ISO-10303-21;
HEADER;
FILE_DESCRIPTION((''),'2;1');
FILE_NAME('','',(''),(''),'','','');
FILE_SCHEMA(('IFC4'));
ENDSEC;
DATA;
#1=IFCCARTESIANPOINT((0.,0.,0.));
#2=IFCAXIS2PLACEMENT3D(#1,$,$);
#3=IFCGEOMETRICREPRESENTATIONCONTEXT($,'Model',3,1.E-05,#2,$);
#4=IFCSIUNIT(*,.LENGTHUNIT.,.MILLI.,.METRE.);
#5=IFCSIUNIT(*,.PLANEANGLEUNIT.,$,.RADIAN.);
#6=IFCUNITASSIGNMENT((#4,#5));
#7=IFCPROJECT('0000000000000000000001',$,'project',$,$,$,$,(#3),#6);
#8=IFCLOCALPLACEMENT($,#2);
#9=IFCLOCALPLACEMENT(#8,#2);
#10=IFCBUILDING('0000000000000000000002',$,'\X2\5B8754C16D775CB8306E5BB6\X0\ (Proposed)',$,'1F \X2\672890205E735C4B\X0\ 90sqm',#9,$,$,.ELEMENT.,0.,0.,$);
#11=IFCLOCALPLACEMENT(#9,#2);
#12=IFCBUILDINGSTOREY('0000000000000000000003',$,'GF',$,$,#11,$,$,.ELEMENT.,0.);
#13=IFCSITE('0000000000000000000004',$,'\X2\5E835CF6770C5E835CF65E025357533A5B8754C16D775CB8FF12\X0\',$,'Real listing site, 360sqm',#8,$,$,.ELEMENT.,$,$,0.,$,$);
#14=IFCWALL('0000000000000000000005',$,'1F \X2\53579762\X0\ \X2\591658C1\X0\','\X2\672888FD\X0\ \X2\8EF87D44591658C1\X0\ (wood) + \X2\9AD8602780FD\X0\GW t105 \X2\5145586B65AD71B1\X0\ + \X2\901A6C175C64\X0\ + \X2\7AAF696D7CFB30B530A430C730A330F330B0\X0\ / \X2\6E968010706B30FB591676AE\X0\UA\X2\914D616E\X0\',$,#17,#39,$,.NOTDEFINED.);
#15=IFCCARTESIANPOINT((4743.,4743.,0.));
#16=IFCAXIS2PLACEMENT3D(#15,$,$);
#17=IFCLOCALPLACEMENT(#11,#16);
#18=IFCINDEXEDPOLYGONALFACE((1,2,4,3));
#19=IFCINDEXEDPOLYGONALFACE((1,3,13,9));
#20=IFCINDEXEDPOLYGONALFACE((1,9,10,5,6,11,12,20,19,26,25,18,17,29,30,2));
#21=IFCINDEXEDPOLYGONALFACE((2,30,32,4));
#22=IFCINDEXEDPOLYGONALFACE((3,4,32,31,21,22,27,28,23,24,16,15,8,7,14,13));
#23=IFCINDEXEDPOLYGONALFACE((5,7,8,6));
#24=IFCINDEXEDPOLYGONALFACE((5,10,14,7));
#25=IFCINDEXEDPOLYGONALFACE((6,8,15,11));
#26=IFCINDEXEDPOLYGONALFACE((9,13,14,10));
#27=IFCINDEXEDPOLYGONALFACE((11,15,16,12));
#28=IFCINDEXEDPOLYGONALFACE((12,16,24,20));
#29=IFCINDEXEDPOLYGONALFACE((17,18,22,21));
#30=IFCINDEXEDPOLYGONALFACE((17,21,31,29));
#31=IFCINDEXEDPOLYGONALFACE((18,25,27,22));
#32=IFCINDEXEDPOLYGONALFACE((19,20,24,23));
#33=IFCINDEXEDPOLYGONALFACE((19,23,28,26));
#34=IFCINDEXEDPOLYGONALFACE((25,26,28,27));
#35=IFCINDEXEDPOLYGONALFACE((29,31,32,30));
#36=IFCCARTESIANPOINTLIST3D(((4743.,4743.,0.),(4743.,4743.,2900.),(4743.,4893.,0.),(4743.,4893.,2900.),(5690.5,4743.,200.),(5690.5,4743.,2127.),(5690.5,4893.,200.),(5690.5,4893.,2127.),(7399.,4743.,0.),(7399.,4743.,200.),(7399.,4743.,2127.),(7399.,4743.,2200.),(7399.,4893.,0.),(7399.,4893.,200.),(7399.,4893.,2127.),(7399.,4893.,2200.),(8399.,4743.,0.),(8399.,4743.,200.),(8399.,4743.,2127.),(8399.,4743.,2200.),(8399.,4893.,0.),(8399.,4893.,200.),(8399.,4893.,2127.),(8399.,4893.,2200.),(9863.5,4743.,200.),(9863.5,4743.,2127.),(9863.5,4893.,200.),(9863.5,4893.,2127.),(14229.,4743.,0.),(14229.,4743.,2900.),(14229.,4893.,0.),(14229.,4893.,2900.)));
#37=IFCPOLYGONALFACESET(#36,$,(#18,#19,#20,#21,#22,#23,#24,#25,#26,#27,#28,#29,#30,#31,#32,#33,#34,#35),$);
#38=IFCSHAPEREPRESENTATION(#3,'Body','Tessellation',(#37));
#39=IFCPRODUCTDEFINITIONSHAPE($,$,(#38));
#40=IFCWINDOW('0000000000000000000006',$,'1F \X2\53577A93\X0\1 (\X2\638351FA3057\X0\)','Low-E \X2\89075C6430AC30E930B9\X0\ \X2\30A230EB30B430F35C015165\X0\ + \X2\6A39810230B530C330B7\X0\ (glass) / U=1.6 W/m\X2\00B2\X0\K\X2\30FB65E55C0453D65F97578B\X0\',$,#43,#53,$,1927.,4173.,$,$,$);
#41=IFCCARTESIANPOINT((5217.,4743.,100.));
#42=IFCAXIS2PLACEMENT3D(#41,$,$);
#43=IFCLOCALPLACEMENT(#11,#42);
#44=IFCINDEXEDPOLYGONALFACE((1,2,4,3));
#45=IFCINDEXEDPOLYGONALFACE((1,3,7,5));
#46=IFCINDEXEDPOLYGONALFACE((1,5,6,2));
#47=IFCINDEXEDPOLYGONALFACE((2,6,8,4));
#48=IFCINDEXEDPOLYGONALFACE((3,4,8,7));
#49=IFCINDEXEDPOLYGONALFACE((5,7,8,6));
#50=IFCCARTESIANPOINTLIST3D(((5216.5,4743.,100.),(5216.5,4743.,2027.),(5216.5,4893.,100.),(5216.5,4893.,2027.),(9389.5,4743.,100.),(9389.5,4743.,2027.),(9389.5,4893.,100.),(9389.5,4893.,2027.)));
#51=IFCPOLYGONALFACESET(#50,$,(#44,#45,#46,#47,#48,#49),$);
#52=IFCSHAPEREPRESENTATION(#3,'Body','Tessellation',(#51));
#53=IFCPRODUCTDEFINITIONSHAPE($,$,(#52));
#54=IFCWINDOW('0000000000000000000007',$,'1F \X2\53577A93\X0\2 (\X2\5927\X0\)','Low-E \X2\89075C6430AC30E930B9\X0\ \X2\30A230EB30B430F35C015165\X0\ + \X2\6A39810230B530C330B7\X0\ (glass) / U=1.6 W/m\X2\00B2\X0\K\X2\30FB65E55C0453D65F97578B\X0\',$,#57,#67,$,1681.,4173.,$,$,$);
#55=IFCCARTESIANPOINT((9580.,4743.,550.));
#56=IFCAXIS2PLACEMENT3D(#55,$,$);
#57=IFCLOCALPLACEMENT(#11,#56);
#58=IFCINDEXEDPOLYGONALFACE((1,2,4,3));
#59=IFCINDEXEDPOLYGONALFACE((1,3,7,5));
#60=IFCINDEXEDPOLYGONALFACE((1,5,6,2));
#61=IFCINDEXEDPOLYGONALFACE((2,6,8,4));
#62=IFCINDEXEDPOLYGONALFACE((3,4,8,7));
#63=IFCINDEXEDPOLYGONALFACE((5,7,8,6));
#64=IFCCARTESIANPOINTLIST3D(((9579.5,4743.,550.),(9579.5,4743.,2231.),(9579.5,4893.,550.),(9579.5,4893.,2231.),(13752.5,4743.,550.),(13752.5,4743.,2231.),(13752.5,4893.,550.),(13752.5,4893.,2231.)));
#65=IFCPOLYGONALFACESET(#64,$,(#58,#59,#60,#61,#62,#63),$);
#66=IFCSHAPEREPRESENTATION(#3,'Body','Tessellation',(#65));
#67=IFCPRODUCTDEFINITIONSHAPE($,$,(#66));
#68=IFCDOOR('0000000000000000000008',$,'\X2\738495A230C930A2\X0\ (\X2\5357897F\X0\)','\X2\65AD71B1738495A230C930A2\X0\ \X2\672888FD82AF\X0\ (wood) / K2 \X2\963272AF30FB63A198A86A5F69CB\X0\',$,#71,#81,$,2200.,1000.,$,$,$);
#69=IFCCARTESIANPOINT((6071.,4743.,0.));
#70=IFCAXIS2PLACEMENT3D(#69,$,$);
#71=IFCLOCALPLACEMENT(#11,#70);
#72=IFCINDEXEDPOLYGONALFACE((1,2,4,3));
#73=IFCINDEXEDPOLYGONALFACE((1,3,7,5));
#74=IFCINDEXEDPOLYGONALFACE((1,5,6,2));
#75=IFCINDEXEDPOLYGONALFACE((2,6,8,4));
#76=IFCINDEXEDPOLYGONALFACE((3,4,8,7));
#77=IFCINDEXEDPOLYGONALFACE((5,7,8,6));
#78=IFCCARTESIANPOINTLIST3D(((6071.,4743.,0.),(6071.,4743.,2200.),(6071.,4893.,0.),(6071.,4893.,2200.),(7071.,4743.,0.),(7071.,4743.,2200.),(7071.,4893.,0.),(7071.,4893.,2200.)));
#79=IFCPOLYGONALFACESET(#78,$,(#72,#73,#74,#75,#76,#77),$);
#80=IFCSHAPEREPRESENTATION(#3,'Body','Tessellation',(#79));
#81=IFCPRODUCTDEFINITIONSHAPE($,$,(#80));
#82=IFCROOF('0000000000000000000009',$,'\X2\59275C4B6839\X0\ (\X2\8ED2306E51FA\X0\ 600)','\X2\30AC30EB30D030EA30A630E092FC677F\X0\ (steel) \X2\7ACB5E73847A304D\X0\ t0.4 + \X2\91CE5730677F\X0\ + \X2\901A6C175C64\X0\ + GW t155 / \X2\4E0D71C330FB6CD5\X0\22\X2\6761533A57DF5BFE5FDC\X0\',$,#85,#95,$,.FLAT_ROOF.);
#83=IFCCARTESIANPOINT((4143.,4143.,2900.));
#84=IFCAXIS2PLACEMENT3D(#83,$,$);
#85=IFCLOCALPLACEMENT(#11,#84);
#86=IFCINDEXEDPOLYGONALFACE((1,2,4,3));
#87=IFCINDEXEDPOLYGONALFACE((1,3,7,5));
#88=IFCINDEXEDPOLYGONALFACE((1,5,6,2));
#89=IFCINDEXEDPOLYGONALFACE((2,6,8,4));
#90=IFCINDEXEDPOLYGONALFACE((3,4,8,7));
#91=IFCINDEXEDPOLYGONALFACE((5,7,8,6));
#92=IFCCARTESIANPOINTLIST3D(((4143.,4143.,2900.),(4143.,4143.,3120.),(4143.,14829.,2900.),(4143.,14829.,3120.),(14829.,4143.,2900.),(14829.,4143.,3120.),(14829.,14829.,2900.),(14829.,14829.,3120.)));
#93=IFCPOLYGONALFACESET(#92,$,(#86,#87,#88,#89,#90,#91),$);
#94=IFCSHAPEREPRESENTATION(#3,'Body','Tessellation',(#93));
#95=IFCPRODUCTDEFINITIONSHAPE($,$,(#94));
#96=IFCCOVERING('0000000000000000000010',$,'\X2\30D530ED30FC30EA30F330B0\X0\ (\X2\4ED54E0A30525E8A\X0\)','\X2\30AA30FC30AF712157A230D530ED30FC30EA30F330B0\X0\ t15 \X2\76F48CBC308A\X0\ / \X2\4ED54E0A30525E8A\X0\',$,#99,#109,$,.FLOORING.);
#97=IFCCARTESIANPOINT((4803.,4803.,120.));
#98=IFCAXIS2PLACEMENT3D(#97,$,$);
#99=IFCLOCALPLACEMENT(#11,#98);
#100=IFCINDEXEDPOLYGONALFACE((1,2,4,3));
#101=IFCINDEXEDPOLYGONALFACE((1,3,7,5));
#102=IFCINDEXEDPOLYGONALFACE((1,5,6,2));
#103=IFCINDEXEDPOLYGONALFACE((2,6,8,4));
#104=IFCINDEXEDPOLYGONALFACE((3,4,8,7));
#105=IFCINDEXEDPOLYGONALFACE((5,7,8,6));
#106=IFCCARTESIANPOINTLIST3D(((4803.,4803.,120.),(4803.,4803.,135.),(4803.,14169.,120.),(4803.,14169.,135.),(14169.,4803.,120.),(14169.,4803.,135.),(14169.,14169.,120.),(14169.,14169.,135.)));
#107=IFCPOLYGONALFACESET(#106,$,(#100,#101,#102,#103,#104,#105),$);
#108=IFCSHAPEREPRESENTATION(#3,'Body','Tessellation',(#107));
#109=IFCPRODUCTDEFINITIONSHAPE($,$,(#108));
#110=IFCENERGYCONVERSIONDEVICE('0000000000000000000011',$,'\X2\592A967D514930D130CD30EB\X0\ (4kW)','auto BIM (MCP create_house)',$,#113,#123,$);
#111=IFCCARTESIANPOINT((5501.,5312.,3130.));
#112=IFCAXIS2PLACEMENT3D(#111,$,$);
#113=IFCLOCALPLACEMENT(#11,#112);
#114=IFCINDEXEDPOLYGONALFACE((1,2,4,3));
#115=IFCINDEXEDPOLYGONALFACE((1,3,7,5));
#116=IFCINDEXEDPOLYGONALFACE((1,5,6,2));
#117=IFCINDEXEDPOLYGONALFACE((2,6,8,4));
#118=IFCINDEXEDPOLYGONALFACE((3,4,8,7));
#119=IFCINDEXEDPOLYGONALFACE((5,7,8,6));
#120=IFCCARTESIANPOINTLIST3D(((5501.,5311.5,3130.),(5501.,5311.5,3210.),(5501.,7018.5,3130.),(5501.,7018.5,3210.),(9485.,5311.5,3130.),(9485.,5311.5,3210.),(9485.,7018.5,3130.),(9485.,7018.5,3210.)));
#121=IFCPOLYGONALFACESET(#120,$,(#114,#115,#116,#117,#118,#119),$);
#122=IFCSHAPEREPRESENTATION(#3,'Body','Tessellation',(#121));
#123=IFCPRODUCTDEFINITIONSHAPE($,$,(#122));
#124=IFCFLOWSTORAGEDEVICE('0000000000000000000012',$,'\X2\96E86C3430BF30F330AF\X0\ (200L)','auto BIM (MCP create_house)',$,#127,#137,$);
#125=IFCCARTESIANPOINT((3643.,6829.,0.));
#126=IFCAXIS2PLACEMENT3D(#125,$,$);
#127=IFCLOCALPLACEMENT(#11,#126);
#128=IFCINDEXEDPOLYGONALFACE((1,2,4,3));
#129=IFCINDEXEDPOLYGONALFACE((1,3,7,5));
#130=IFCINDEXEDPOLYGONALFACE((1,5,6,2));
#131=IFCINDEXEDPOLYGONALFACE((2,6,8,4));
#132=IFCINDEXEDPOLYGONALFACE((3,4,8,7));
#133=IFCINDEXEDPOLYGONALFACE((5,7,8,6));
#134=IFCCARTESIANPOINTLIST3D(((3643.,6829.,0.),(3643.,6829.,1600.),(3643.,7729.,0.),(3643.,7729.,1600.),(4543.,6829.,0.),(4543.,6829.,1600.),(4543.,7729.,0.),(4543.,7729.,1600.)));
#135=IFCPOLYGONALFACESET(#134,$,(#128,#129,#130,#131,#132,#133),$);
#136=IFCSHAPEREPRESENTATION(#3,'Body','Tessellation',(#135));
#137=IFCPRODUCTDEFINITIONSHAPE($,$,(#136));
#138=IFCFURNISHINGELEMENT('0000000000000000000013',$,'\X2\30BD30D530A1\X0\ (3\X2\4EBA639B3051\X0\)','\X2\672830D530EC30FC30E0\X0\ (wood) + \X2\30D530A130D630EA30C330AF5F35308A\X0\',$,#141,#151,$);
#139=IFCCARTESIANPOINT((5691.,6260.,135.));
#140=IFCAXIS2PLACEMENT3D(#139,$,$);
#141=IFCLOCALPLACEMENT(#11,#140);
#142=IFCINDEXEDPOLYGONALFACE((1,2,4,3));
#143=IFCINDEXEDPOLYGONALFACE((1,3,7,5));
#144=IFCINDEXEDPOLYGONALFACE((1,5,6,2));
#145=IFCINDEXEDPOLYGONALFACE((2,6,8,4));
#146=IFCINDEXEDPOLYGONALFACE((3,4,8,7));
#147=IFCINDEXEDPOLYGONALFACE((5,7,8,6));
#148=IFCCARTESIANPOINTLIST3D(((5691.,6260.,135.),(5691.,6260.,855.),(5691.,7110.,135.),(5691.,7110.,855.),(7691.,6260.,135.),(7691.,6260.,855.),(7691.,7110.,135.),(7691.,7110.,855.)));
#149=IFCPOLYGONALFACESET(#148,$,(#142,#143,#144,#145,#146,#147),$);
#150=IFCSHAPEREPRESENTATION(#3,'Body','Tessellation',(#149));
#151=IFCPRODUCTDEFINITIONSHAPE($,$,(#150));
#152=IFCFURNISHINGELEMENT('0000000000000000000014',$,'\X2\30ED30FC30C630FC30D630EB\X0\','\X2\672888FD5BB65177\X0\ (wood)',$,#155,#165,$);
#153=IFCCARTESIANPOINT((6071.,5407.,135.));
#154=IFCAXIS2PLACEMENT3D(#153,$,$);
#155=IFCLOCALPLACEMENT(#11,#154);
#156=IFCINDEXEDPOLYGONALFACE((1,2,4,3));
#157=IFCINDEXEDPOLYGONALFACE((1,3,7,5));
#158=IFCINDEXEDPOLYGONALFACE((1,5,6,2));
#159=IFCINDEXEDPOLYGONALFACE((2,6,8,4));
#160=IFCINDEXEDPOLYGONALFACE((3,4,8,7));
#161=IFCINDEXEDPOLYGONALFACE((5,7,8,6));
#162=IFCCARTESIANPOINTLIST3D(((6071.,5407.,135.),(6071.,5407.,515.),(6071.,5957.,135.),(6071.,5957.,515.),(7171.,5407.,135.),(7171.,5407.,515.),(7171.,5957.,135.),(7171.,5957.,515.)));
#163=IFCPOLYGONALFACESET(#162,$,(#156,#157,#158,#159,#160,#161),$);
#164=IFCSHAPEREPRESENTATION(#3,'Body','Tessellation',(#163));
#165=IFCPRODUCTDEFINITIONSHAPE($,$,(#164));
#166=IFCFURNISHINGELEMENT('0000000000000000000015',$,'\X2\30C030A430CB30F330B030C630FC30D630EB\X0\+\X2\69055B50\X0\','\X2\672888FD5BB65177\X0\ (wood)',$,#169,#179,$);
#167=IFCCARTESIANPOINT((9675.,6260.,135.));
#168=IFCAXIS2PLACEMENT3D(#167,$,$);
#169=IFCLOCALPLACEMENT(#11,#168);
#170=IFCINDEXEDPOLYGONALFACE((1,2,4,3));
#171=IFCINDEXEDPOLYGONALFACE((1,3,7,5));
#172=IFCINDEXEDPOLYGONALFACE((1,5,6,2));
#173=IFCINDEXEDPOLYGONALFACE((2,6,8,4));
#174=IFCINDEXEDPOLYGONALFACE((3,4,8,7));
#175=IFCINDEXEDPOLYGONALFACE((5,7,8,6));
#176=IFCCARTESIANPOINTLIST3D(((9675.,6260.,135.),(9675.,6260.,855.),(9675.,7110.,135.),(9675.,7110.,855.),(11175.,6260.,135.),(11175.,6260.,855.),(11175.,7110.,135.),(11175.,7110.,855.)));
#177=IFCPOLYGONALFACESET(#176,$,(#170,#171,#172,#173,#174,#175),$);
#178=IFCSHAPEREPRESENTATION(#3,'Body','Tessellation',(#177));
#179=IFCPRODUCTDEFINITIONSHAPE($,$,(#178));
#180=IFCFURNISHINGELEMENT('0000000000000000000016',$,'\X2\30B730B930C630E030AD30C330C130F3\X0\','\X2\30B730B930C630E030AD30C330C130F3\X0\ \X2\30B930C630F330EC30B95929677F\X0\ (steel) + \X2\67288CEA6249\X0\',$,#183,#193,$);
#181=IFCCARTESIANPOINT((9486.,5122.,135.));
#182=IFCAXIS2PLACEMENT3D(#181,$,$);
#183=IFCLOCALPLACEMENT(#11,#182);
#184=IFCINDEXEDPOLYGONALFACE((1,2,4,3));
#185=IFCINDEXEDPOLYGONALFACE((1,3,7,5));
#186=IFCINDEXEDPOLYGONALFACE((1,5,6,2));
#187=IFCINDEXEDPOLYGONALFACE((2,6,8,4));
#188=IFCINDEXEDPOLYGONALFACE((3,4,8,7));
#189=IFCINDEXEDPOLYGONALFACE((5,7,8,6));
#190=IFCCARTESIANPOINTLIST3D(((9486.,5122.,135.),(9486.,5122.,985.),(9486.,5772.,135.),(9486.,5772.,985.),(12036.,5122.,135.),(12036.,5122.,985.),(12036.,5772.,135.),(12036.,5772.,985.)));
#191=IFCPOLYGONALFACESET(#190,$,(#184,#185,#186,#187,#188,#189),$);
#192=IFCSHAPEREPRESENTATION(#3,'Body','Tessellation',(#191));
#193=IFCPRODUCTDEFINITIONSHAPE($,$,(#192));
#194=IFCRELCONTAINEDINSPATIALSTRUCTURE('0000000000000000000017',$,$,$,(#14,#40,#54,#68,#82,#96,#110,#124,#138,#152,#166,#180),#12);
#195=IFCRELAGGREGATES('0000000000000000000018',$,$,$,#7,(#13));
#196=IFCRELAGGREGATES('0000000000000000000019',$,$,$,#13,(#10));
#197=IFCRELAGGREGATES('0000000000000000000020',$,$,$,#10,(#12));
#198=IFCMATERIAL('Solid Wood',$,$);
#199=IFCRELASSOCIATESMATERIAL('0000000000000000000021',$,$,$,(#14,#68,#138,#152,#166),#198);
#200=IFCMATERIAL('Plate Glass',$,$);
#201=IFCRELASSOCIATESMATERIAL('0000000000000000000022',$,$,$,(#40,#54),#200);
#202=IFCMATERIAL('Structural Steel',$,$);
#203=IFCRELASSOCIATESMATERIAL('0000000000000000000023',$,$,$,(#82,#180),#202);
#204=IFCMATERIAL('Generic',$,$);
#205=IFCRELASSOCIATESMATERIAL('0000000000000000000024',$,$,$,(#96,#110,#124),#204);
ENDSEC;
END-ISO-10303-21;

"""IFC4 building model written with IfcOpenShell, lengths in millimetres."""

from ifc_helpers import new_model, si_unit, frame, frame_2d, origin, place, context, project, spatial, rectangle, extrude, material, element, fill, save


model = new_model("IFC4")

# Units and contexts
model_context = context("Model", 3, precision=1e-05, world=origin())
ifc_project = project(units=[si_unit("LENGTHUNIT", "METRE", prefix="MILLI"), si_unit("PLANEANGLEUNIT", "RADIAN")], contexts=[model_context])

# Site, building, storey
site_placement = place(None, origin())
site = spatial("IfcSite", under=ifc_project, at=site_placement, Name="広島県広島市南区宇品海岸２", ObjectType="Real listing site, 360sqm", CompositionType="ELEMENT", RefElevation=0.0)
building_placement = place(site_placement, origin())
building = spatial("IfcBuilding", under=site, at=building_placement, Name="宇品海岸の家 (Proposed)", ObjectType="1F 木造平屋 90sqm", CompositionType="ELEMENT", ElevationOfRefHeight=0.0, ElevationOfTerrain=0.0)
storey_placement = place(building_placement, origin())
storey = spatial("IfcBuildingStorey", under=building, at=storey_placement, Name="GF", CompositionType="ELEMENT", Elevation=0.0)

# Shared definitions
ifc_material_1 = material(Name="Solid Wood")

# Wall, openings, windows, door
wall_1_placement = place(storey_placement, frame((4743.0, 4743.0, 0.0)))
wall_1 = element("IfcWall", 1, at=wall_1_placement, inside=storey, material=ifc_material_1, Name="1F 南面 外壁", Description="木製 軸組外壁 (wood) + 高性能GW t105 充填断熱 + 通気層 + 窯業系サイディング / 準耐火・外皮UA配慮", PredefinedType="NOTDEFINED", context=model_context, shape_type="SweptSolid", body=[
    extrude(rectangle(XDim=9486.0, YDim=150.0, at=frame_2d((4743.0, 75.0))), frame((4743.0, 4743.0, 0.0)), (0.0, 0.0, 1.0), 2900.0),
])
opening_1_placement = place(storey_placement, frame((5217.0, 4743.0, 100.0)))
opening_1 = element("IfcOpeningElement", 2, at=opening_1_placement, cuts=wall_1, PredefinedType="NOTDEFINED", context=model_context, shape_type="SweptSolid", body=[
    extrude(rectangle(XDim=4173.0, YDim=150.0, at=frame_2d((2086.0, 75.0))), frame((5217.0, 4743.0, 100.0)), (0.0, 0.0, 1.0), 1927.0),
])
opening_2_placement = place(storey_placement, frame((9580.0, 4743.0, 550.0)))
opening_2 = element("IfcOpeningElement", 3, at=opening_2_placement, cuts=wall_1, PredefinedType="NOTDEFINED", context=model_context, shape_type="SweptSolid", body=[
    extrude(rectangle(XDim=4173.0, YDim=150.0, at=frame_2d((2086.0, 75.0))), frame((9580.0, 4743.0, 550.0)), (0.0, 0.0, 1.0), 1681.0),
])
opening_3_placement = place(storey_placement, frame((6071.0, 4743.0, 0.0)))
opening_3 = element("IfcOpeningElement", 4, at=opening_3_placement, cuts=wall_1, PredefinedType="NOTDEFINED", context=model_context, shape_type="SweptSolid", body=[
    extrude(rectangle(XDim=1000.0, YDim=150.0, at=frame_2d((500.0, 75.0))), frame((6071.0, 4743.0, 0.0)), (0.0, 0.0, 1.0), 2200.0),
])
ifc_material_2 = material(Name="Plate Glass")
window_1_placement = place(storey_placement, frame((5217.0, 4743.0, 100.0)))
window_1 = element("IfcWindow", 5, at=window_1_placement, inside=storey, material=ifc_material_2, Name="1F 南窓1 (掃出し)", Description="Low-E 複層ガラス アルゴン封入 + 樹脂サッシ (glass) / U=1.6 W/m²K・日射取得型", OverallHeight=1927.0, OverallWidth=4173.0, context=model_context, shape_type="SweptSolid", body=[
    extrude(rectangle(XDim=4173.0, YDim=150.0, at=frame_2d((2086.0, 75.0))), frame((5217.0, 4743.0, 100.0)), (0.0, 0.0, 1.0), 1927.0),
])
fill(opening_1, window_1)
window_2_placement = place(storey_placement, frame((9580.0, 4743.0, 550.0)))
window_2 = element("IfcWindow", 6, at=window_2_placement, inside=storey, material=ifc_material_2, Name="1F 南窓2 (大)", Description="Low-E 複層ガラス アルゴン封入 + 樹脂サッシ (glass) / U=1.6 W/m²K・日射取得型", OverallHeight=1681.0, OverallWidth=4173.0, context=model_context, shape_type="SweptSolid", body=[
    extrude(rectangle(XDim=4173.0, YDim=150.0, at=frame_2d((2086.0, 75.0))), frame((9580.0, 4743.0, 550.0)), (0.0, 0.0, 1.0), 1681.0),
])
fill(opening_2, window_2)
door_placement = place(storey_placement, frame((6071.0, 4743.0, 0.0)))
door = element("IfcDoor", 7, at=door_placement, inside=storey, material=ifc_material_1, Name="玄関ドア (南西)", Description="断熱玄関ドア 木製芯 (wood) / K2 防犯・採風機構", OverallHeight=2200.0, OverallWidth=1000.0, context=model_context, shape_type="SweptSolid", body=[
    extrude(rectangle(XDim=1000.0, YDim=150.0, at=frame_2d((500.0, 75.0))), frame((6071.0, 4743.0, 0.0)), (0.0, 0.0, 1.0), 2200.0),
])
fill(opening_3, door)

# Roof
ifc_material_3 = material(Name="Structural Steel")
roof_placement = place(storey_placement, frame((4143.0, 4143.0, 2900.0)))
element("IfcRoof", 8, at=roof_placement, inside=storey, material=ifc_material_3, Name="大屋根 (軒の出 600)", Description="ガルバリウム鋼板 (steel) 立平葺き t0.4 + 野地板 + 通気層 + GW t155 / 不燃・法22条区域対応", PredefinedType="FLAT_ROOF", context=model_context, shape_type="SweptSolid", body=[
    extrude(rectangle(XDim=10686.0, YDim=10686.0, at=frame_2d((5343.0, 5343.0))), frame((4143.0, 4143.0, 2900.0)), (0.0, 0.0, 1.0), 220.0),
])

# Covering
ifc_material_4 = material(Name="Generic")
covering_placement = place(storey_placement, frame((4803.0, 4803.0, 120.0)))
element("IfcCovering", 9, at=covering_placement, inside=storey, material=ifc_material_4, Name="フローリング (仕上げ床)", Description="オーク無垢フローリング t15 直貼り / 仕上げ床", PredefinedType="FLOORING", context=model_context, shape_type="SweptSolid", body=[
    extrude(rectangle(XDim=9366.0, YDim=9366.0, at=frame_2d((4683.0, 4683.0))), frame((4803.0, 4803.0, 120.0)), (0.0, 0.0, 1.0), 15.0),
])

# Energy conversion device
energy_conversion_device_placement = place(storey_placement, frame((5501.0, 5312.0, 3130.0)))
element("IfcEnergyConversionDevice", 10, at=energy_conversion_device_placement, inside=storey, material=ifc_material_4, Name="太陽光パネル (4kW)", Description="auto BIM (MCP create_house)", context=model_context, shape_type="SweptSolid", body=[
    extrude(rectangle(XDim=3984.0, YDim=1707.0, at=frame_2d((1992.0, 853.0))), frame((5501.0, 5312.0, 3130.0)), (0.0, 0.0, 1.0), 80.0),
])

# Flow storage device
flow_storage_device_placement = place(storey_placement, frame((3643.0, 6829.0, 0.0)))
element("IfcFlowStorageDevice", 11, at=flow_storage_device_placement, inside=storey, material=ifc_material_4, Name="雨水タンク (200L)", Description="auto BIM (MCP create_house)", context=model_context, shape_type="SweptSolid", body=[
    extrude(rectangle(XDim=900.0, YDim=900.0, at=frame_2d((450.0, 450.0))), frame((3643.0, 6829.0, 0.0)), (0.0, 0.0, 1.0), 1600.0),
])

# Furnishing elements
furnishing_1_placement = place(storey_placement, frame((5691.0, 6260.0, 135.0)))
element("IfcFurnishingElement", 12, at=furnishing_1_placement, inside=storey, material=ifc_material_1, Name="ソファ (3人掛け)", Description="木フレーム (wood) + ファブリック張り", context=model_context, shape_type="SweptSolid", body=[
    extrude(rectangle(XDim=2000.0, YDim=850.0, at=frame_2d((1000.0, 425.0))), frame((5691.0, 6260.0, 135.0)), (0.0, 0.0, 1.0), 720.0),
])
furnishing_2_placement = place(storey_placement, frame((6071.0, 5407.0, 135.0)))
element("IfcFurnishingElement", 13, at=furnishing_2_placement, inside=storey, material=ifc_material_1, Name="ローテーブル", Description="木製家具 (wood)", context=model_context, shape_type="SweptSolid", body=[
    extrude(rectangle(XDim=1100.0, YDim=550.0, at=frame_2d((550.0, 275.0))), frame((6071.0, 5407.0, 135.0)), (0.0, 0.0, 1.0), 380.0),
])
furnishing_3_placement = place(storey_placement, frame((9675.0, 6260.0, 135.0)))
element("IfcFurnishingElement", 14, at=furnishing_3_placement, inside=storey, material=ifc_material_1, Name="ダイニングテーブル+椅子", Description="木製家具 (wood)", context=model_context, shape_type="SweptSolid", body=[
    extrude(rectangle(XDim=1500.0, YDim=850.0, at=frame_2d((750.0, 425.0))), frame((9675.0, 6260.0, 135.0)), (0.0, 0.0, 1.0), 720.0),
])
furnishing_4_placement = place(storey_placement, frame((9486.0, 5122.0, 135.0)))
element("IfcFurnishingElement", 15, at=furnishing_4_placement, inside=storey, material=ifc_material_3, Name="システムキッチン", Description="システムキッチン ステンレス天板 (steel) + 木質扉", context=model_context, shape_type="SweptSolid", body=[
    extrude(rectangle(XDim=2550.0, YDim=650.0, at=frame_2d((1275.0, 325.0))), frame((9486.0, 5122.0, 135.0)), (0.0, 0.0, 1.0), 850.0),
])

save(model, "model.ifc")
